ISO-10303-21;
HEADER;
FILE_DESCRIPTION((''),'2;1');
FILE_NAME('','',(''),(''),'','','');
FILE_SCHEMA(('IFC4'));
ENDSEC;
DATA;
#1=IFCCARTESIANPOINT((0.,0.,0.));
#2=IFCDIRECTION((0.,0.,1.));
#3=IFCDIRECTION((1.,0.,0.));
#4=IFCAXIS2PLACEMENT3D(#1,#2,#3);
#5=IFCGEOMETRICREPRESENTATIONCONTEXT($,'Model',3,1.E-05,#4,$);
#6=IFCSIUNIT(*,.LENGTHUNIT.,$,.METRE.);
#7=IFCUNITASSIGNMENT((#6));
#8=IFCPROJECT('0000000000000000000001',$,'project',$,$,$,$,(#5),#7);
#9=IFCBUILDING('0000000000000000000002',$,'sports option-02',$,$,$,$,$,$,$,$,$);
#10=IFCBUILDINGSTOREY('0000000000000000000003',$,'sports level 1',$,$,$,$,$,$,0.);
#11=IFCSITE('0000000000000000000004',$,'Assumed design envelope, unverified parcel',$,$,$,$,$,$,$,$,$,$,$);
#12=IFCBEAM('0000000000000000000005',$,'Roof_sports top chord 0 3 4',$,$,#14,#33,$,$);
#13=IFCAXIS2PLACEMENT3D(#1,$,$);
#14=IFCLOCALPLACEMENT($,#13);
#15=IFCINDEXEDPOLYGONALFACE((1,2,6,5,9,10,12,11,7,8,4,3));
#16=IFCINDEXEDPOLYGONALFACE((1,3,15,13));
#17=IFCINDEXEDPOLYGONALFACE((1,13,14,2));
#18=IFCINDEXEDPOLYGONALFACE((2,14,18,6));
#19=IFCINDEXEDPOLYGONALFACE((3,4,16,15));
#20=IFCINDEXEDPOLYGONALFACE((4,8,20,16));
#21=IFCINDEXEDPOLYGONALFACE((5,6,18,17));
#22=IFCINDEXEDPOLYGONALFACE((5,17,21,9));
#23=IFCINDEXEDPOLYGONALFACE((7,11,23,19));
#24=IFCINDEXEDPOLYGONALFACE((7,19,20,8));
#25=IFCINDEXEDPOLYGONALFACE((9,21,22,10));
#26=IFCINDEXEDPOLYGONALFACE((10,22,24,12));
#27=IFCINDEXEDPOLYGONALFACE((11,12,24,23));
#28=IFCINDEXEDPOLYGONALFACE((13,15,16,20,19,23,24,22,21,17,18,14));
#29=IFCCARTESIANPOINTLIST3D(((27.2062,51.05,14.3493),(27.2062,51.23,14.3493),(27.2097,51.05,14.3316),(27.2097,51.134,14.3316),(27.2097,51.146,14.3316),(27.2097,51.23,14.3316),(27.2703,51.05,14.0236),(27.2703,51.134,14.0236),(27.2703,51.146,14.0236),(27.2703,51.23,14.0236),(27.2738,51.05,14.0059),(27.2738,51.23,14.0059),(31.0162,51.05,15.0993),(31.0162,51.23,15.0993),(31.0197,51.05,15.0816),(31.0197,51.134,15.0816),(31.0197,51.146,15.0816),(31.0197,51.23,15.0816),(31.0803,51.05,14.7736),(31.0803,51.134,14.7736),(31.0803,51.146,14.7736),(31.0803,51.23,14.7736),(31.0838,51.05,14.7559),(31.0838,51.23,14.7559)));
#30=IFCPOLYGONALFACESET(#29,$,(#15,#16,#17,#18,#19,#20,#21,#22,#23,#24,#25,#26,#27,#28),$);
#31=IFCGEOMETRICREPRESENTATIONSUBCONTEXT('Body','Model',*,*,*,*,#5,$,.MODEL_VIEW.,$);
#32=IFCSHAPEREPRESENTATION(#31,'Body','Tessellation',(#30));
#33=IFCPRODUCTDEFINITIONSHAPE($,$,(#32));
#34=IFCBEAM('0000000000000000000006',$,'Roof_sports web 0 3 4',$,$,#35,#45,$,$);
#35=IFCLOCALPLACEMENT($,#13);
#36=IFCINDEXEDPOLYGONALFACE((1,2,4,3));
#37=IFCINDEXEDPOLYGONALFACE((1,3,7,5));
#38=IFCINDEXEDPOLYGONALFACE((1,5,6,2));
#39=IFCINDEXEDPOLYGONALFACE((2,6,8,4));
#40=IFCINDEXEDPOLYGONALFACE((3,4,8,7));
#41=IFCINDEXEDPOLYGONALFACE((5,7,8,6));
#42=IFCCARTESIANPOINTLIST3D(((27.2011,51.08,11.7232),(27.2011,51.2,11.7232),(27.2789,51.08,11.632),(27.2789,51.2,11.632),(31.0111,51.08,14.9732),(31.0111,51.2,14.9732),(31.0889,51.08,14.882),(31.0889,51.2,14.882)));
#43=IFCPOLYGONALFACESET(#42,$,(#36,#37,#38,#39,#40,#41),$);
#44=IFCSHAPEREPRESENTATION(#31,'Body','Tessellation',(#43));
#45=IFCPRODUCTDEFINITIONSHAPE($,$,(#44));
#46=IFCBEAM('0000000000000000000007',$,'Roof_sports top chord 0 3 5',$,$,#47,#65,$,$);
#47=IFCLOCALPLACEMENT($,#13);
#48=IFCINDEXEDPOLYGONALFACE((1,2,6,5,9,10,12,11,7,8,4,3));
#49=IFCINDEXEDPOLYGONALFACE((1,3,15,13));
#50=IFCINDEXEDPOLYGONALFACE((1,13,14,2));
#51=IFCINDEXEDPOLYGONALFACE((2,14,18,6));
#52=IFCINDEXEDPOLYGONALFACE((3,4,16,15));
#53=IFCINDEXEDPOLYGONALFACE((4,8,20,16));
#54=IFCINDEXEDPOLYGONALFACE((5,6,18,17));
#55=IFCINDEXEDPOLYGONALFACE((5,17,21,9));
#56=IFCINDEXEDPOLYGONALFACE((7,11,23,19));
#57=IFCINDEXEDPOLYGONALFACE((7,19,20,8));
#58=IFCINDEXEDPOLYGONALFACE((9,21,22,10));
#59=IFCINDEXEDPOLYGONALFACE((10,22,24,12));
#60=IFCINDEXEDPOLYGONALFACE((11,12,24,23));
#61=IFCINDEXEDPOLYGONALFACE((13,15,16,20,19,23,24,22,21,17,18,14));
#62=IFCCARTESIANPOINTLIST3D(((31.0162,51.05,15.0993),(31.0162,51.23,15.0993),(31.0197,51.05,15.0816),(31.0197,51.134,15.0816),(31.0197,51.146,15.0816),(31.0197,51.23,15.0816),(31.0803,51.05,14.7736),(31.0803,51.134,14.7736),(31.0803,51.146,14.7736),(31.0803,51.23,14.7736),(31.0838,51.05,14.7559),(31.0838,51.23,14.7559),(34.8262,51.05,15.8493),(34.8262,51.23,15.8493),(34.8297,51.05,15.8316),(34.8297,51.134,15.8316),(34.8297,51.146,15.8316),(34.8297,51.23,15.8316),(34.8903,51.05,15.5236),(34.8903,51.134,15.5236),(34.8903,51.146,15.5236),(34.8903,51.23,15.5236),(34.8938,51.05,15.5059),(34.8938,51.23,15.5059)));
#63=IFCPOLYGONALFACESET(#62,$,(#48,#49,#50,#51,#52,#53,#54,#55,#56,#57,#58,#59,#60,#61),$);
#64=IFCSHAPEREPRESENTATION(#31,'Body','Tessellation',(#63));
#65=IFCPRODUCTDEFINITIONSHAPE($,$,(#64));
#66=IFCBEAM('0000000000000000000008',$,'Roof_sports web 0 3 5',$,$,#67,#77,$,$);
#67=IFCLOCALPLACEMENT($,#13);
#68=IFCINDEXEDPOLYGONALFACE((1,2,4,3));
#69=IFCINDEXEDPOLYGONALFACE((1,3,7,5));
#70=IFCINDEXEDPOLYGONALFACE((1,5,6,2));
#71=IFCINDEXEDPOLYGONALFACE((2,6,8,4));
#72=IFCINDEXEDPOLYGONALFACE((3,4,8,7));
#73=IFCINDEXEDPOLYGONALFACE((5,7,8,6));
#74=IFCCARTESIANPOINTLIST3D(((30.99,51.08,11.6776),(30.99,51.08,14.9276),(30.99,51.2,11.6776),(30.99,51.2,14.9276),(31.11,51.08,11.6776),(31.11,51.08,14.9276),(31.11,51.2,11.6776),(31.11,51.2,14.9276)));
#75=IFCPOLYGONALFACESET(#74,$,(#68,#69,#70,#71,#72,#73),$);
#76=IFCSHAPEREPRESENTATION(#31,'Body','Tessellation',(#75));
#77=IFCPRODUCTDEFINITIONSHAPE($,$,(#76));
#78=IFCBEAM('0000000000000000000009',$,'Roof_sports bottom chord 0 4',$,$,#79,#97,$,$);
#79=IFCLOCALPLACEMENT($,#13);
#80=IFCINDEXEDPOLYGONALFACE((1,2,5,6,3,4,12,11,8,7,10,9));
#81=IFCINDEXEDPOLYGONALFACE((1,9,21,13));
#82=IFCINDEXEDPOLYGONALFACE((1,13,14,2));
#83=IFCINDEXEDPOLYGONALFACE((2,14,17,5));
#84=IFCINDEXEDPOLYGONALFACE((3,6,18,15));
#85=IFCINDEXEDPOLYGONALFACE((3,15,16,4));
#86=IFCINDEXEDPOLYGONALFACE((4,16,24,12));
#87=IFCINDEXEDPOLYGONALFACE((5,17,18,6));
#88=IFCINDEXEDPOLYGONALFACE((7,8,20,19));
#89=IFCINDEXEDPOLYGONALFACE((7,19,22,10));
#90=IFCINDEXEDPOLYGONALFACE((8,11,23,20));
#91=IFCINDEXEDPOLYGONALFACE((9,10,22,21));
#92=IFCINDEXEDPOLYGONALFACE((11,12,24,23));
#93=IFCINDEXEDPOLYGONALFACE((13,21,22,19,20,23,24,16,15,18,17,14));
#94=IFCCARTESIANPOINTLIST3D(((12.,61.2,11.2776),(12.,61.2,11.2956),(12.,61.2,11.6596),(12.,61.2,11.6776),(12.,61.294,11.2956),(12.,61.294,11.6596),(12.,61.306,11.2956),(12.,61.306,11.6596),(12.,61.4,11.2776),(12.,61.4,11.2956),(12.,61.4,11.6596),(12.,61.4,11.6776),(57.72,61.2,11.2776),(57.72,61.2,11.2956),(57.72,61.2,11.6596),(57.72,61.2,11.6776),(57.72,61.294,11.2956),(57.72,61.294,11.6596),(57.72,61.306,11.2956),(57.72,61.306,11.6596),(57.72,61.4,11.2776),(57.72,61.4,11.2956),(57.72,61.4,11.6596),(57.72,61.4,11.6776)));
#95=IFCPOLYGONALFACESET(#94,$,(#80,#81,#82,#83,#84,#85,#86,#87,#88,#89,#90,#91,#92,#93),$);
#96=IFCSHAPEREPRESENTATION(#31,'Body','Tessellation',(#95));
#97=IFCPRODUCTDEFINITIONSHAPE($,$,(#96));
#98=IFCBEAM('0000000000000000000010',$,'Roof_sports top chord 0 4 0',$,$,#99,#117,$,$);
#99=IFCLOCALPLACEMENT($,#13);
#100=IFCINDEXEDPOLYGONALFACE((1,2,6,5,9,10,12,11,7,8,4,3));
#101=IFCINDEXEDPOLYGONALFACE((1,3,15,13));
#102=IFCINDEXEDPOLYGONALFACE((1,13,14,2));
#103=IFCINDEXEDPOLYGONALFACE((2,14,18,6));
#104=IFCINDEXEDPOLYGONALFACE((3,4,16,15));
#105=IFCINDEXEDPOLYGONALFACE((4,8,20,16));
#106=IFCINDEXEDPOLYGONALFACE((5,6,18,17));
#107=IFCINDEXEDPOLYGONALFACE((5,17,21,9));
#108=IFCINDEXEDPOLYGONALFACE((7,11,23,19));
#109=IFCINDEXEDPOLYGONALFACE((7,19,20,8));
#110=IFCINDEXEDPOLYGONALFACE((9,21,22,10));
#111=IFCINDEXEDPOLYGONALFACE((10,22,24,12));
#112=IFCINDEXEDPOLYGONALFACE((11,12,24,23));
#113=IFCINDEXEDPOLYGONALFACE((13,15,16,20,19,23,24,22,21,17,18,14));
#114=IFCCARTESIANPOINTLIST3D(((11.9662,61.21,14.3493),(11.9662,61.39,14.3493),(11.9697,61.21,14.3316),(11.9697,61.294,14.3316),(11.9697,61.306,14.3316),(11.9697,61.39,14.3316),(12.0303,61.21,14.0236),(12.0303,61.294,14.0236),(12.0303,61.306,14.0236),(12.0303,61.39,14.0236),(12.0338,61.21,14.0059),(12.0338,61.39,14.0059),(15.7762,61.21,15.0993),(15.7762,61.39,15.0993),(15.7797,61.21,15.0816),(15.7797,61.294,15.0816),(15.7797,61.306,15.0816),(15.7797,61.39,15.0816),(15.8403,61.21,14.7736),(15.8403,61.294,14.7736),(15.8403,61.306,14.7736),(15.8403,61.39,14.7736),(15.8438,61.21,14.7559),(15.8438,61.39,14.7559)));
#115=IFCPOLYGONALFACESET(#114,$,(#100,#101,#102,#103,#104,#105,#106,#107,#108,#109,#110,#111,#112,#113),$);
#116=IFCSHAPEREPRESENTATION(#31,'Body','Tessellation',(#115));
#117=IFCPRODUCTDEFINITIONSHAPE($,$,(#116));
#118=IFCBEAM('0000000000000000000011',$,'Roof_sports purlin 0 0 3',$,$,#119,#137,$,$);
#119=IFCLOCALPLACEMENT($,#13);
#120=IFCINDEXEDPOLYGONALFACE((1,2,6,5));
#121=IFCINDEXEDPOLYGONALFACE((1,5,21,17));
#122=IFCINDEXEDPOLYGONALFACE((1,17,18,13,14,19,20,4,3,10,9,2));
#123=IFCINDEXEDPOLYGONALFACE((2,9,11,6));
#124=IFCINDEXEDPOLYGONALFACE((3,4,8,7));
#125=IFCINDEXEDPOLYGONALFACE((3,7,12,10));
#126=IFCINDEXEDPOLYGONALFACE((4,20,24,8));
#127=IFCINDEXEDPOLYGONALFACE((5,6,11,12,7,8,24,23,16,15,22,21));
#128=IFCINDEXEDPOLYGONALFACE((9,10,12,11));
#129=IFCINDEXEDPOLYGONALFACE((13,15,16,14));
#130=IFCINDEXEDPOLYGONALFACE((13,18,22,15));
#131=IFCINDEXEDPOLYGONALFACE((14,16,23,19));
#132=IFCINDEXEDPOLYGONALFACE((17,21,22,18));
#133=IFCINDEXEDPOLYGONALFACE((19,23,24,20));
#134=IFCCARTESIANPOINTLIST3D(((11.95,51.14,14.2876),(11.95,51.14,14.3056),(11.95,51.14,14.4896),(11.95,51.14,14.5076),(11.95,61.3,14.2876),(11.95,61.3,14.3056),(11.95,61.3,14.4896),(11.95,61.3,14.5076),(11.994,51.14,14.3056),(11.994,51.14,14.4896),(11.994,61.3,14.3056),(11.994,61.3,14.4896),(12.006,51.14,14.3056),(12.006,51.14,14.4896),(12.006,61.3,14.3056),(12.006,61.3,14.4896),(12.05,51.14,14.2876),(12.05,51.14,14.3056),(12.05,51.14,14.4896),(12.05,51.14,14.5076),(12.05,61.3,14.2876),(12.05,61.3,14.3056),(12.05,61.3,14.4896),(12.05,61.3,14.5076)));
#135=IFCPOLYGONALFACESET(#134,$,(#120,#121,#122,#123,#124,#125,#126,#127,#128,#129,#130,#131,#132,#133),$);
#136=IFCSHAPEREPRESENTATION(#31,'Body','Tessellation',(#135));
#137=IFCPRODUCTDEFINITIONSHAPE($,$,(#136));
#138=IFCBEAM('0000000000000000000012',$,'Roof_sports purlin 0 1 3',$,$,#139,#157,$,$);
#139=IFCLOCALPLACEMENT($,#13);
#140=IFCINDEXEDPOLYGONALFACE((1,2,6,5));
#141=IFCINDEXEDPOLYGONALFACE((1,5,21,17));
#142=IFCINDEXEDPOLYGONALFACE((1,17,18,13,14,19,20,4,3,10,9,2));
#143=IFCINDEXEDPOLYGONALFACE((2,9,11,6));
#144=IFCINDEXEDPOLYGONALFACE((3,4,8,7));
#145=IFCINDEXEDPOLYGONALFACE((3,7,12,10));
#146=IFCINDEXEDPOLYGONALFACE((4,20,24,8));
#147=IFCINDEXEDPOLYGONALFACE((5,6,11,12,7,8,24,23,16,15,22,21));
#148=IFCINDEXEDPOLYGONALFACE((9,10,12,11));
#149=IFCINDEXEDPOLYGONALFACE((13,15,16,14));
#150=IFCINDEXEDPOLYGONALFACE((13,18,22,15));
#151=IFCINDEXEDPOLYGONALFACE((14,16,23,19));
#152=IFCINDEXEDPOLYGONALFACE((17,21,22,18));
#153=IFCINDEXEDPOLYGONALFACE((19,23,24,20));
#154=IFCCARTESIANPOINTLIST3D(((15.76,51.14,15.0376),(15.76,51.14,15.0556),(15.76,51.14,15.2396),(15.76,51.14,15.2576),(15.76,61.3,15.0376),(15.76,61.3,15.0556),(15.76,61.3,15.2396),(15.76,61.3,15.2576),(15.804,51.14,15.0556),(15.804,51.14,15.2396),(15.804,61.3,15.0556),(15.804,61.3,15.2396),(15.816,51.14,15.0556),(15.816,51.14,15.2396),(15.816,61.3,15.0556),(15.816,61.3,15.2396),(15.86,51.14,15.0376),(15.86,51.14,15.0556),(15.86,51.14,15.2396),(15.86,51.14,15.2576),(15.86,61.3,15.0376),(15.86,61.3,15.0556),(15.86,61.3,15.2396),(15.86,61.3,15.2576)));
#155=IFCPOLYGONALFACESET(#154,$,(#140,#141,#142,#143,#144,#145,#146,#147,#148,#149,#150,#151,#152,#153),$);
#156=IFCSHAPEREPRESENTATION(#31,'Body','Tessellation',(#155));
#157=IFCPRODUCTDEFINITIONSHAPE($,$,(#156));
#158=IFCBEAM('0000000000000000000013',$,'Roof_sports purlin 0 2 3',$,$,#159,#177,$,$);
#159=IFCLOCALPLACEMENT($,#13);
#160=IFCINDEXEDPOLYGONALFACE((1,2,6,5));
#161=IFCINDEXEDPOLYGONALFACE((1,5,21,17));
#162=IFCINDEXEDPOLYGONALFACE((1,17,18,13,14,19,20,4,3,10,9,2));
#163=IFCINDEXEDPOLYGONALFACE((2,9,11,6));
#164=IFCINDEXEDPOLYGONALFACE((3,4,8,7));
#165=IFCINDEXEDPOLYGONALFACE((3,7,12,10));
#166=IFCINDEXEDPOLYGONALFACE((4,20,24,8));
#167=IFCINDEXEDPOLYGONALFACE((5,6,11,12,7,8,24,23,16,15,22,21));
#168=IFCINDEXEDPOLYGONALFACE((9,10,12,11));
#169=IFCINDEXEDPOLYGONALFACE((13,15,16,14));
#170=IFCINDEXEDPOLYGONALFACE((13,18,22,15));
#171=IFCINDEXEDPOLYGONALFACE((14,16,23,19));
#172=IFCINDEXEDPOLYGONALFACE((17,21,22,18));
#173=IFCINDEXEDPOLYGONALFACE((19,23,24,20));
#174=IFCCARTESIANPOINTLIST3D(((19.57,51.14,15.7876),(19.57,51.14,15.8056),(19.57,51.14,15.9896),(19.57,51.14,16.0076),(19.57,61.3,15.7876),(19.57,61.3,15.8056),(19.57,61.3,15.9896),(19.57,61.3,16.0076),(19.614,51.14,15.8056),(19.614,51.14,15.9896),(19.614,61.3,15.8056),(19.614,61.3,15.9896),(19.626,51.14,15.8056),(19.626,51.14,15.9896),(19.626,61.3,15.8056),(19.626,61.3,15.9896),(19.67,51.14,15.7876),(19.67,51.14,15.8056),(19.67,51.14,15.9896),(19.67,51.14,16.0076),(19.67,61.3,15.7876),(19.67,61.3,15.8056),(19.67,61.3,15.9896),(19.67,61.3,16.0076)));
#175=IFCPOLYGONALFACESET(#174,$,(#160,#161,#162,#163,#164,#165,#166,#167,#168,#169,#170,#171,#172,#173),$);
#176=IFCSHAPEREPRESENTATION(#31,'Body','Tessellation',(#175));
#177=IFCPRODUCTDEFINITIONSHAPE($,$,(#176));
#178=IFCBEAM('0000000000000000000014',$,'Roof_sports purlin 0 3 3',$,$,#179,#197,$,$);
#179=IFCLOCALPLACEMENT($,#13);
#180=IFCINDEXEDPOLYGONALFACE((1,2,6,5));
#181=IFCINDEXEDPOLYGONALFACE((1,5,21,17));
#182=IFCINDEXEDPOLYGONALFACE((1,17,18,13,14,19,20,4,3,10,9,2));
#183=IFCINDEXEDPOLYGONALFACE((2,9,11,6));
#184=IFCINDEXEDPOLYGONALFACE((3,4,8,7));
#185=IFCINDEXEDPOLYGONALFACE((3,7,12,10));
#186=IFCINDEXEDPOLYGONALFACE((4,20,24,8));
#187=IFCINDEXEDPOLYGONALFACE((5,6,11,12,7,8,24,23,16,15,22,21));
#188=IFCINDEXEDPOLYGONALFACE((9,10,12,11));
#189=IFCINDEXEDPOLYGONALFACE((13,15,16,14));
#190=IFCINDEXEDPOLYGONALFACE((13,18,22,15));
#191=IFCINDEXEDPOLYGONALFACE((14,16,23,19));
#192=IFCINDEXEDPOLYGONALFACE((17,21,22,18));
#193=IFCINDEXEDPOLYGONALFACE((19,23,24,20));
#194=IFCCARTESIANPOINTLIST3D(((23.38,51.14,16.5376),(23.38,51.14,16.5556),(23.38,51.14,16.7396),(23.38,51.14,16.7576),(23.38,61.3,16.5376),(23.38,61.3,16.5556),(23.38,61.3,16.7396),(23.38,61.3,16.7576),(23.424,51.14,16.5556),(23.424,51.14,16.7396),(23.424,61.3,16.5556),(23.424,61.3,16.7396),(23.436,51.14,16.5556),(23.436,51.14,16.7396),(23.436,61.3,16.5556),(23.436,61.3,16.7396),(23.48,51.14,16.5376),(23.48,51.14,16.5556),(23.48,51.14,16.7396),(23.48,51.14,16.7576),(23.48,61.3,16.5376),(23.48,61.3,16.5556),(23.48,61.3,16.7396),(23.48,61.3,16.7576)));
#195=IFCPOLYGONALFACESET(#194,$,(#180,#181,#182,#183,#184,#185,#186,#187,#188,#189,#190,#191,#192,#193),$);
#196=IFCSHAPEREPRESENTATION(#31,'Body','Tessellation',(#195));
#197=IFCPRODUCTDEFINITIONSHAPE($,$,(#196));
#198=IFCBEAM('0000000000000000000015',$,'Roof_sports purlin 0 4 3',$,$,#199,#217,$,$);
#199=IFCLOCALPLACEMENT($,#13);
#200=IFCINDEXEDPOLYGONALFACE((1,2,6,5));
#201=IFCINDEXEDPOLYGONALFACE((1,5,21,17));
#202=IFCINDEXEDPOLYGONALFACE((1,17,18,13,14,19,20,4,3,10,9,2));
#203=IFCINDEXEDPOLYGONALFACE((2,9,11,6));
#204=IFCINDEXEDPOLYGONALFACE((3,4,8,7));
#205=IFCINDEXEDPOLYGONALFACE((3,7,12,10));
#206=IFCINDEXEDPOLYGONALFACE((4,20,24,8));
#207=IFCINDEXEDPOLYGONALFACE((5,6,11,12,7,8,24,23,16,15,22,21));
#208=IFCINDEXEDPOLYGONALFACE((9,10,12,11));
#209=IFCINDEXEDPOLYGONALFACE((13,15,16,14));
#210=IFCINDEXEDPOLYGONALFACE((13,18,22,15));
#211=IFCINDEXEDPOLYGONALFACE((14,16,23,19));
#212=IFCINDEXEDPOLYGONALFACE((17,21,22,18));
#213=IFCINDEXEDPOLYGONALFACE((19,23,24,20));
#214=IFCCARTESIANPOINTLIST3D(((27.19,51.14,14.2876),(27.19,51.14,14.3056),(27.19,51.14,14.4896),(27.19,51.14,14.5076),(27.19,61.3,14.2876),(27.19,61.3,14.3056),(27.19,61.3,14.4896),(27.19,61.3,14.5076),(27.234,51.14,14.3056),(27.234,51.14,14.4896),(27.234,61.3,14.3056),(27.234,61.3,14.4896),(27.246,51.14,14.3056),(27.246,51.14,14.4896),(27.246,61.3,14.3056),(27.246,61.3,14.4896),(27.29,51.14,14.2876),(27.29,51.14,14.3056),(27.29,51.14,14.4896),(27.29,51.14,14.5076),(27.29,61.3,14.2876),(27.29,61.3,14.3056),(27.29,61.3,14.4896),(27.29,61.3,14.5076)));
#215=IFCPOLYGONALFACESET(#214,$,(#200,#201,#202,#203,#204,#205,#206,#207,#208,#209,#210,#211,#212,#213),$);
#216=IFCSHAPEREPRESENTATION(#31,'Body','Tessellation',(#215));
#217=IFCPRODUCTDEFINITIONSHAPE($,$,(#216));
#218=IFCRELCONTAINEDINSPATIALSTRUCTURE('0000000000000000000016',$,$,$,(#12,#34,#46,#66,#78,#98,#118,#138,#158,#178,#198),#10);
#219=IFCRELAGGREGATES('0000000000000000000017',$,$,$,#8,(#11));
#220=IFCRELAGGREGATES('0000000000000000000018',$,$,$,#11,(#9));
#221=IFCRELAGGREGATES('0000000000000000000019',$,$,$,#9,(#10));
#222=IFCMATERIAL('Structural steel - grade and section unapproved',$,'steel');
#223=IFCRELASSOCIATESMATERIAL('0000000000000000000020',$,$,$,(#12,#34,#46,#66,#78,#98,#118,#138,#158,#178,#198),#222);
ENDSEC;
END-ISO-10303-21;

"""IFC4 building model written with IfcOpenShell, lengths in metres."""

from ifc_helpers import new_model, si_unit, frame, origin_with_axes, place, context, subcontext, project, spatial, rectangle, i_section, extrude, material, element, save


model = new_model("IFC4")

# Units and contexts
model_context = context("Model", 3, precision=1e-05, world=origin_with_axes())
body_context = subcontext(model_context, "Body", "Model", "MODEL_VIEW")
ifc_project = project(units=[si_unit("LENGTHUNIT", "METRE")], contexts=[model_context])

# Site, building, storey
site = spatial("IfcSite", under=ifc_project, Name="Assumed design envelope, unverified parcel")
building = spatial("IfcBuilding", under=site, Name="sports option-02")
storey = spatial("IfcBuildingStorey", under=building, Name="sports level 1", Elevation=0.0)

# Shared definitions
ifc_material_1 = material(Name="Structural steel - grade and section unapproved", Category="steel")

# Beams
beam_1_placement = place(None, frame((27.24, 51.14, 14.1776), z_axis=(0.981171, 0.0, 0.193143), x_axis=(0.0, 1.0, 0.0)))
element("IfcBeam", 1, at=beam_1_placement, inside=storey, material=ifc_material_1, Name="Roof_sports top chord 0 3 4", context=body_context, shape_type="SweptSolid", body=[
    extrude(i_section(OverallWidth=0.18, OverallDepth=0.35, WebThickness=0.012, FlangeThickness=0.018, FilletRadius=0.0), origin_with_axes(), (0.0, 0.0, 1.0), 3.8831),
])
beam_2_placement = place(None, frame((27.24, 51.14, 11.6776), z_axis=(0.760805, 0.0, 0.648981), x_axis=(0.0, 1.0, 0.0)))
element("IfcBeam", 2, at=beam_2_placement, inside=storey, material=ifc_material_1, Name="Roof_sports web 0 3 4", context=body_context, shape_type="SweptSolid", body=[
    extrude(rectangle(XDim=0.12, YDim=0.12), origin_with_axes(), (0.0, 0.0, 1.0), 5.0079),
])
beam_3_placement = place(None, frame((31.05, 51.14, 14.9276), z_axis=(0.98117, 0.0, 0.193144), x_axis=(0.0, 1.0, 0.0)))
element("IfcBeam", 3, at=beam_3_placement, inside=storey, material=ifc_material_1, Name="Roof_sports top chord 0 3 5", context=body_context, shape_type="SweptSolid", body=[
    extrude(i_section(OverallWidth=0.18, OverallDepth=0.35, WebThickness=0.012, FlangeThickness=0.018, FilletRadius=0.0), origin_with_axes(), (0.0, 0.0, 1.0), 3.8831),
])
beam_4_placement = place(None, frame((31.05, 51.14, 11.6776), z_axis=(0.0, 0.0, 1.0), x_axis=(-1.0, 0.0, 0.0)))
element("IfcBeam", 4, at=beam_4_placement, inside=storey, material=ifc_material_1, Name="Roof_sports web 0 3 5", context=body_context, shape_type="SweptSolid", body=[
    extrude(rectangle(XDim=0.12, YDim=0.12), origin_with_axes(), (0.0, 0.0, 1.0), 3.25),
])
beam_5_placement = place(None, frame((12.0, 61.3, 11.4776), z_axis=(1.0, 0.0, 0.0), x_axis=(0.0, 1.0, 0.0)))
element("IfcBeam", 5, at=beam_5_placement, inside=storey, material=ifc_material_1, Name="Roof_sports bottom chord 0 4", context=body_context, shape_type="SweptSolid", body=[
    extrude(i_section(OverallWidth=0.2, OverallDepth=0.4, WebThickness=0.012, FlangeThickness=0.018, FilletRadius=0.0), origin_with_axes(), (0.0, 0.0, 1.0), 45.72),
])
beam_6_placement = place(None, frame((12.0, 61.3, 14.1776), z_axis=(0.981171, 0.0, 0.193144), x_axis=(0.0, 1.0, 0.0)))
element("IfcBeam", 6, at=beam_6_placement, inside=storey, material=ifc_material_1, Name="Roof_sports top chord 0 4 0", context=body_context, shape_type="SweptSolid", body=[
    extrude(i_section(OverallWidth=0.18, OverallDepth=0.35, WebThickness=0.012, FlangeThickness=0.018, FilletRadius=0.0), origin_with_axes(), (0.0, 0.0, 1.0), 3.8831),
])
for number, where, z_axis, x_axis, name in (
    (7, (12.0, 51.14, 14.3976), (0.0, 1.0, 0.0), (-1.0, 0.0, 0.0), "Roof_sports purlin 0 0 3"),
    (8, (15.81, 51.14, 15.1476), (0.0, 1.0, 0.0), (-1.0, 0.0, 0.0), "Roof_sports purlin 0 1 3"),
    (9, (19.62, 51.14, 15.8976), (0.0, 1.0, 0.0), (-1.0, 0.0, 0.0), "Roof_sports purlin 0 2 3"),
    (10, (23.43, 51.14, 16.6476), (0.0, 1.0, 0.0), (-1.0, 0.0, 0.0), "Roof_sports purlin 0 3 3"),
    (11, (27.24, 51.14, 14.3976), (0.0, 1.0, 0.0), (-1.0, 0.0, 0.0), "Roof_sports purlin 0 4 3"),
):
    element("IfcBeam", number, at=place(None, frame(where, z_axis=z_axis, x_axis=x_axis)), inside=storey, material=ifc_material_1, Name=name, context=body_context, shape_type="SweptSolid", body=[
        extrude(i_section(OverallWidth=0.1, OverallDepth=0.22, WebThickness=0.012, FlangeThickness=0.018, FilletRadius=0.0), origin_with_axes(), (0.0, 0.0, 1.0), 10.16),
    ])

save(model, "model.ifc")
